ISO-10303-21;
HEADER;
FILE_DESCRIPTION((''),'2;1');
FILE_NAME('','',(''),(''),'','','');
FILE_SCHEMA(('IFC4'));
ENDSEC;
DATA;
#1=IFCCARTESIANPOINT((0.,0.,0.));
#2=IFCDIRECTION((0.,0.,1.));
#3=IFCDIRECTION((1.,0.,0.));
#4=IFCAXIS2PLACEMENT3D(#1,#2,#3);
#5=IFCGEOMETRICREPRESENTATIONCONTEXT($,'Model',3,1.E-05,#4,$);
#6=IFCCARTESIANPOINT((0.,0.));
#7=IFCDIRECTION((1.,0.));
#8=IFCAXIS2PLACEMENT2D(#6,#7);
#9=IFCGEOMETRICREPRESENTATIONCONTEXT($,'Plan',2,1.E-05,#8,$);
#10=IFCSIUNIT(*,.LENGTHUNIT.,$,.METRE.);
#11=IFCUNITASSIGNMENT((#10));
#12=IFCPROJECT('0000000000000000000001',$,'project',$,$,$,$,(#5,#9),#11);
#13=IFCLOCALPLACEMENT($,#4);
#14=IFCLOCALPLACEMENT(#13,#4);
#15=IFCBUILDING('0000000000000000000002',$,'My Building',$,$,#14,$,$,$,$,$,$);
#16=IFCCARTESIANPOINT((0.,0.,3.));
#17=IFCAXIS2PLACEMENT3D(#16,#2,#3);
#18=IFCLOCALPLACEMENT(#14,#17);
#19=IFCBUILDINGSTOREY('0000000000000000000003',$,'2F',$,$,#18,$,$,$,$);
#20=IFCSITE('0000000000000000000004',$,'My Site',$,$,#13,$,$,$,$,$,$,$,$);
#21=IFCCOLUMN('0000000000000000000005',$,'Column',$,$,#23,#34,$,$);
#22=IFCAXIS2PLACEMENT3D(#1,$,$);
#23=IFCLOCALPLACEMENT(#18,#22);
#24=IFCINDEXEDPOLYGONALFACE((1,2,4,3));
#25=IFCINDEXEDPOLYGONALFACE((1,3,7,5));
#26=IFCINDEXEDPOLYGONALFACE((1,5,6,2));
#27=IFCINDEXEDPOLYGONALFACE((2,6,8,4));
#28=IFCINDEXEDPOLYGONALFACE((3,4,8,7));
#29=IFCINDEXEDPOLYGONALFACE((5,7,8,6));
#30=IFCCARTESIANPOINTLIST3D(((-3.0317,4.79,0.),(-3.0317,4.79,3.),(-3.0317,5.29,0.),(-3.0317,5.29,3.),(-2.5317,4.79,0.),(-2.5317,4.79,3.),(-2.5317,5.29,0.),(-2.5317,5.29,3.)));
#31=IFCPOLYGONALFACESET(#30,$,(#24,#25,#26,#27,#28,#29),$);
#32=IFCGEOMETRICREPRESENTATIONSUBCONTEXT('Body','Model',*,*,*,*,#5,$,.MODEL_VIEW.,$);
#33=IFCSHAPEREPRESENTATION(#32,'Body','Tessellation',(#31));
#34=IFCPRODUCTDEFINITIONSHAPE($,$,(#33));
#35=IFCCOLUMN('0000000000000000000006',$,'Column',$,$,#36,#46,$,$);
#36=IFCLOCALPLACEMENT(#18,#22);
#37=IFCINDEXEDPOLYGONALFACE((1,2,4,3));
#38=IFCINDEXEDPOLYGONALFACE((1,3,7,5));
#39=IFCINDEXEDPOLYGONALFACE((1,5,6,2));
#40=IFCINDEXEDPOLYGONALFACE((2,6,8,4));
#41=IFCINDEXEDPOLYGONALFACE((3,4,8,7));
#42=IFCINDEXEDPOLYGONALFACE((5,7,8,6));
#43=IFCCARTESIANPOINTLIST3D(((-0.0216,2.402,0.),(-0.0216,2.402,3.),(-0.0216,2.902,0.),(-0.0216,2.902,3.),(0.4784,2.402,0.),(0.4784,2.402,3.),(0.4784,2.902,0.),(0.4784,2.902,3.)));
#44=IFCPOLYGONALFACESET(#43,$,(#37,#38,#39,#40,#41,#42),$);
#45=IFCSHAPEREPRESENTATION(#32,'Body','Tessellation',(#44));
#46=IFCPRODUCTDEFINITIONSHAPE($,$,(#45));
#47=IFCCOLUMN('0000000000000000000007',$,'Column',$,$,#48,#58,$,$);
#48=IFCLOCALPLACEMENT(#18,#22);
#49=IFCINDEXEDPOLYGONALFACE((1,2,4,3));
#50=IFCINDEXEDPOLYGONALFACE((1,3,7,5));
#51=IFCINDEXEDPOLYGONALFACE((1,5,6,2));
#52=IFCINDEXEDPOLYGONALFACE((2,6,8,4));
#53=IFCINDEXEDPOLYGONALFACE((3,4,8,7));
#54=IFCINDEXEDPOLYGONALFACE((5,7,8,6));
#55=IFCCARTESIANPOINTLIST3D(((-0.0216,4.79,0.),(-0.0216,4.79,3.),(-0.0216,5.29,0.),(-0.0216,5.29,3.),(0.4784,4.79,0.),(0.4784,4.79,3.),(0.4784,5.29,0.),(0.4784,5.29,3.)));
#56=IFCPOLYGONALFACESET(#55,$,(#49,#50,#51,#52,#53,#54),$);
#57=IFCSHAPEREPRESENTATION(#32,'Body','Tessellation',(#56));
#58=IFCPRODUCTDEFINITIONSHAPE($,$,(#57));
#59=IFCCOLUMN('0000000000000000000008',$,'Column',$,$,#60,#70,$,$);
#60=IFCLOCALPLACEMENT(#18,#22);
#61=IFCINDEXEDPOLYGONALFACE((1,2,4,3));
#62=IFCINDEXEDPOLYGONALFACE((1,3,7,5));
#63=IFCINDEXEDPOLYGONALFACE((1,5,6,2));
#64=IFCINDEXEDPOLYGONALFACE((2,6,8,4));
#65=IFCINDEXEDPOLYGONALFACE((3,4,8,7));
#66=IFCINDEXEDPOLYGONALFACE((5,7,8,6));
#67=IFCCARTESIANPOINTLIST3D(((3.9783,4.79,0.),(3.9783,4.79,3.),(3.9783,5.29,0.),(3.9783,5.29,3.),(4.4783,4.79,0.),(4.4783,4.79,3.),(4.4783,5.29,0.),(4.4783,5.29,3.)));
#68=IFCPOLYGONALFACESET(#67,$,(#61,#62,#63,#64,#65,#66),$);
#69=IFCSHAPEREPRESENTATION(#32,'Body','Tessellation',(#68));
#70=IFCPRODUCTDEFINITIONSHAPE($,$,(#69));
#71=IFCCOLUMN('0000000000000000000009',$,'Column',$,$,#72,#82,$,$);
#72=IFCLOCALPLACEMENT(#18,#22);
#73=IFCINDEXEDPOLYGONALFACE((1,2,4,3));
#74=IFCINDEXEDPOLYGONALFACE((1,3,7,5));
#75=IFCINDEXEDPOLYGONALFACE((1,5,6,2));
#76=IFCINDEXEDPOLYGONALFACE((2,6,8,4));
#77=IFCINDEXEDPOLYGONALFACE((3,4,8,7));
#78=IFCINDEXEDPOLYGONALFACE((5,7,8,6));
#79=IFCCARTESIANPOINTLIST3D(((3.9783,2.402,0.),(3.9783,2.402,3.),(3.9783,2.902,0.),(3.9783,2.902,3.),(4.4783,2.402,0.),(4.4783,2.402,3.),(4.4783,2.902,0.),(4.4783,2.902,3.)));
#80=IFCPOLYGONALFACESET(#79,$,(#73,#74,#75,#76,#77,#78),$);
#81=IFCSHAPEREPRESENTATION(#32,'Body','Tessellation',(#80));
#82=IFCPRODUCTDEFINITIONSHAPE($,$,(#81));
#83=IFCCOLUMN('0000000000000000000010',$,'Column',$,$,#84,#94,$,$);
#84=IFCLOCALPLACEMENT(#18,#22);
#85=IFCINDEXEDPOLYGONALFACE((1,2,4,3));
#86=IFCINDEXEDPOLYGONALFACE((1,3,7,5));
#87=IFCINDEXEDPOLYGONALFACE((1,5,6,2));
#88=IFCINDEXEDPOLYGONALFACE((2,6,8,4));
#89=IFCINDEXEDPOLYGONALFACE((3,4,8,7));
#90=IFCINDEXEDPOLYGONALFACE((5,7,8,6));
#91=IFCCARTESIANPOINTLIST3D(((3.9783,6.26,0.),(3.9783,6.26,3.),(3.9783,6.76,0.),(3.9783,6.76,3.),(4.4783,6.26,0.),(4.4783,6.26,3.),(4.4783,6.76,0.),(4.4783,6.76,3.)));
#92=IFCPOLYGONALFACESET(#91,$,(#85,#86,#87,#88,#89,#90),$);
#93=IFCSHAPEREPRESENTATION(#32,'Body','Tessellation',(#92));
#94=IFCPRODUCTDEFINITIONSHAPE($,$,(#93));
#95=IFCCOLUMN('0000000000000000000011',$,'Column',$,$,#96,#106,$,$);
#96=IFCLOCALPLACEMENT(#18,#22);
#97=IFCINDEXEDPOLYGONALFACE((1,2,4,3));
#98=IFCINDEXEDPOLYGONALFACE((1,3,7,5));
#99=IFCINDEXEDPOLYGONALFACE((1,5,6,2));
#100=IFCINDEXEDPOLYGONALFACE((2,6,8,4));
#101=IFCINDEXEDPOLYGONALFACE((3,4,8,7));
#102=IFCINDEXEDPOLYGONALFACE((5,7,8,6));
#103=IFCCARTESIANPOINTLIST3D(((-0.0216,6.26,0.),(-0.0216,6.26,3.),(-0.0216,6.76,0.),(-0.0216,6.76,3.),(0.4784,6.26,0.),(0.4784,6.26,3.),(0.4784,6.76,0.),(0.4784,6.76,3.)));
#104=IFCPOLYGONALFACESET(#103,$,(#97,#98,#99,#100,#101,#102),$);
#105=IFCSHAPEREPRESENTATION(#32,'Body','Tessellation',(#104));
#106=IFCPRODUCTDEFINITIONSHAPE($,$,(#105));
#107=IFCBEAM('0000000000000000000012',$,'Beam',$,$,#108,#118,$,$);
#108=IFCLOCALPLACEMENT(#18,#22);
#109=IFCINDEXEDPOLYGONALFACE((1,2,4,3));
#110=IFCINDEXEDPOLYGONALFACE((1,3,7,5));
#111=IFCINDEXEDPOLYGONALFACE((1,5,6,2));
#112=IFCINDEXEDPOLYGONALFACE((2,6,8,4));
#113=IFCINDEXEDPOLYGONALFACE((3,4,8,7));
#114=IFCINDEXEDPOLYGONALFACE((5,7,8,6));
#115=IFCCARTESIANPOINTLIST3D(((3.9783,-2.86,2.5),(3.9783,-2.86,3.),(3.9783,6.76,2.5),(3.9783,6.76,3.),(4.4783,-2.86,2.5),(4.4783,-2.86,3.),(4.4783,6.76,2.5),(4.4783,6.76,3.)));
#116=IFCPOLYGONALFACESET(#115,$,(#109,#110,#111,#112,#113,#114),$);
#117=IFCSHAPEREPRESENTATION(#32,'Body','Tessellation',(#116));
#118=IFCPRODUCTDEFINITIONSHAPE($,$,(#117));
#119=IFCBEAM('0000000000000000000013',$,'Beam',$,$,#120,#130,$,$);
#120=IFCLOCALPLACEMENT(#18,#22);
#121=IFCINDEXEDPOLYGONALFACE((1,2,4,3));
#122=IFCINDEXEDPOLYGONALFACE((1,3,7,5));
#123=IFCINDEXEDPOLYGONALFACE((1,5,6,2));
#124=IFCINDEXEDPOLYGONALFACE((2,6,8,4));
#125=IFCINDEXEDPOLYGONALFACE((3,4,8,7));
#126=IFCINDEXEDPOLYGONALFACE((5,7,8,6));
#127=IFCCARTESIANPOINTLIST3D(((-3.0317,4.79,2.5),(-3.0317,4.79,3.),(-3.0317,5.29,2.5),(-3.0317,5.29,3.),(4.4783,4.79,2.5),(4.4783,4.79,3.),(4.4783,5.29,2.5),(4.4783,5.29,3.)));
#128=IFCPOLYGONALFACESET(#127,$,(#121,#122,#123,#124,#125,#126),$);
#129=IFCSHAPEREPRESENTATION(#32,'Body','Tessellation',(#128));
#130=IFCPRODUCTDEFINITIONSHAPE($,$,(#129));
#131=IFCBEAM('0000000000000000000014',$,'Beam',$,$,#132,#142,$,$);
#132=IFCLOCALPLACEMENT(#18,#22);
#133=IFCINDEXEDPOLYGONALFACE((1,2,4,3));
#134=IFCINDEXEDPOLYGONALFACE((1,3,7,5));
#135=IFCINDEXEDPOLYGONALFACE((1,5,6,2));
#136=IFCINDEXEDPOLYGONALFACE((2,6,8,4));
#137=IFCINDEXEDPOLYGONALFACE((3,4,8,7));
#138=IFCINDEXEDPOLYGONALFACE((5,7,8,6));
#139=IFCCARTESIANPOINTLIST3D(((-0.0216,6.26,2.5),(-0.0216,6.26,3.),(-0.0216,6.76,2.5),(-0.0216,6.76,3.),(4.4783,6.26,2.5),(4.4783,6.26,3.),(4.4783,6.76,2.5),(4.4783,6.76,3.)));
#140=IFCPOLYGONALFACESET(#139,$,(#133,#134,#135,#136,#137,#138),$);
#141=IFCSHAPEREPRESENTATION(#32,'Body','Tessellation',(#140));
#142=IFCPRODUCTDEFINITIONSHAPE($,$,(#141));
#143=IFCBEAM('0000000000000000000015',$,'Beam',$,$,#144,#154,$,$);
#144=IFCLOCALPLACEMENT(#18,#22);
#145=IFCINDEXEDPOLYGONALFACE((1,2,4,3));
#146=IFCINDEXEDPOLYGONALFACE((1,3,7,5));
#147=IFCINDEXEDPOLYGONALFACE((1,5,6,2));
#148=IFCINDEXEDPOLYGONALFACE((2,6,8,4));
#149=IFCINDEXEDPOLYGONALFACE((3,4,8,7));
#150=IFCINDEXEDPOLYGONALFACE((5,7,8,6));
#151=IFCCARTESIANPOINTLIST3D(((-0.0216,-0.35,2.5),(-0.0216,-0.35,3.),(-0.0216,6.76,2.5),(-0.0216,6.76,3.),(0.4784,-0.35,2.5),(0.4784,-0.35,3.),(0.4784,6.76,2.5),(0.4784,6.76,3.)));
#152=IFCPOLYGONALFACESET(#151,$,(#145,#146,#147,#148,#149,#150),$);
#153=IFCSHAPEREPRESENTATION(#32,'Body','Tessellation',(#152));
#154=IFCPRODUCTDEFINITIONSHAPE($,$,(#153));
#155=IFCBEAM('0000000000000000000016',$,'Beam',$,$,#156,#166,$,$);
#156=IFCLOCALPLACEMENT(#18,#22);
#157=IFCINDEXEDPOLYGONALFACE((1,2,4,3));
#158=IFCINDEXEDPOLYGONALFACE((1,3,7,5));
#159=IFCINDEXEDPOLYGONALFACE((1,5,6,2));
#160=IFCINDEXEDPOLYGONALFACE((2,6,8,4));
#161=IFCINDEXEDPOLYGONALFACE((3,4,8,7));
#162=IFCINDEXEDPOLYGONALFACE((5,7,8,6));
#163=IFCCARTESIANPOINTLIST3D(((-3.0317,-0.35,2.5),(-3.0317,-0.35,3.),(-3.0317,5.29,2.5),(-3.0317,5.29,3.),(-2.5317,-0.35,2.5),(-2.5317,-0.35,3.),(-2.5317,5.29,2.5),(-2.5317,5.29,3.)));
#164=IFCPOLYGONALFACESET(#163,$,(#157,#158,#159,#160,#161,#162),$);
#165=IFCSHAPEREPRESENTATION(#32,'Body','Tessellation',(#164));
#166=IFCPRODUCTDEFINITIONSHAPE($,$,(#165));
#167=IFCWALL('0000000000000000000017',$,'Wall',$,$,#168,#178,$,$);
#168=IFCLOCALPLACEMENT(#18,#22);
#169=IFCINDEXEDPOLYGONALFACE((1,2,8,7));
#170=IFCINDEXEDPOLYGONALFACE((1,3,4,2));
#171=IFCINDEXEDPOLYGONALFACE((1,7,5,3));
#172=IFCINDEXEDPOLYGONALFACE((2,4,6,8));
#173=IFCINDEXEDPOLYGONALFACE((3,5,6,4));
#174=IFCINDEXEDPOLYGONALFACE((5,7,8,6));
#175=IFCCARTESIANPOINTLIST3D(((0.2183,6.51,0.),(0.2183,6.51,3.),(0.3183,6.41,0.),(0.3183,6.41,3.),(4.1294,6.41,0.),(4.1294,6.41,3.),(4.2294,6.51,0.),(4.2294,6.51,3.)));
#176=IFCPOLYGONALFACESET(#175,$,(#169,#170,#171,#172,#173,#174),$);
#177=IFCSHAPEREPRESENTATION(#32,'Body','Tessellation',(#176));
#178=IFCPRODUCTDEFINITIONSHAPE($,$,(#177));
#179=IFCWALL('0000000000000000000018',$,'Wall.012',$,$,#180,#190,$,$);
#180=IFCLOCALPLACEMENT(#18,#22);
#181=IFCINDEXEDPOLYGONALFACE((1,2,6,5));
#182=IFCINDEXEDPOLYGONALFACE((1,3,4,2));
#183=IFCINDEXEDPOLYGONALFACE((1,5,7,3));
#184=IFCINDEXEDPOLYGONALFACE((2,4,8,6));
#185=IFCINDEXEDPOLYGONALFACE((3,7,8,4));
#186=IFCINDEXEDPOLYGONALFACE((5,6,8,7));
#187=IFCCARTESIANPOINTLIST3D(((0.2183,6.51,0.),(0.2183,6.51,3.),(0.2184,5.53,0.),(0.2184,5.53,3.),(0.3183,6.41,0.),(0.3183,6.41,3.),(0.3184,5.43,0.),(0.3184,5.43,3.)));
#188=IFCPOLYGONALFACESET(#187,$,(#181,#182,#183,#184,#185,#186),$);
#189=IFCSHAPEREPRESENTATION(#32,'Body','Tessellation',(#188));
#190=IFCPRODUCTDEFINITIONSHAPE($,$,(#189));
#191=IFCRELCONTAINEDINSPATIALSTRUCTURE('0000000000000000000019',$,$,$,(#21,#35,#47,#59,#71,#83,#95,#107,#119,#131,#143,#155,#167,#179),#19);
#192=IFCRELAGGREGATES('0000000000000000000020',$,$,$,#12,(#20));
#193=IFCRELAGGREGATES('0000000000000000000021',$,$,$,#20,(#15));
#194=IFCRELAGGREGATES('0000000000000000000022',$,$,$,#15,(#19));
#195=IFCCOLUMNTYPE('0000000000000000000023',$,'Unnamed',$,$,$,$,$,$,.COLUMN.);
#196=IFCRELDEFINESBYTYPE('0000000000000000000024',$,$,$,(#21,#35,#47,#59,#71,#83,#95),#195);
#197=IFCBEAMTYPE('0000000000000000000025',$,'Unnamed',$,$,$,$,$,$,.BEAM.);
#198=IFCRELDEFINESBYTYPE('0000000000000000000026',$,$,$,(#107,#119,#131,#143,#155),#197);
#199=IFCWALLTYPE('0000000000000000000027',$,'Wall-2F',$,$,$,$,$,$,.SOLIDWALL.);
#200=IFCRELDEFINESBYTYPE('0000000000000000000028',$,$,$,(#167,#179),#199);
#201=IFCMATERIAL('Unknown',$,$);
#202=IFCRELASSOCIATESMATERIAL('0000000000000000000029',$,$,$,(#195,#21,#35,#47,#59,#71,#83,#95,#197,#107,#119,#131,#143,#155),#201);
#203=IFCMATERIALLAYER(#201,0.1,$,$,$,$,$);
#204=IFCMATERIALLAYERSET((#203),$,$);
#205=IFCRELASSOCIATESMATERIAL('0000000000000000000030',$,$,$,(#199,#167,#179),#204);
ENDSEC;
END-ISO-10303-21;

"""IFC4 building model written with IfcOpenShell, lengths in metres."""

from ifc_helpers import new_model, si_unit, frame, origin_with_axes, origin_2d_with_axis, place, context, subcontext, project, spatial, line, indexed_curve, rectangle, outline, extrude, material, layer, layer_set, layer_usage, material_profile, profile_set, profile_usage, type_object, element, save


model = new_model("IFC4")

# Units and contexts
model_context = context("Model", 3, precision=1e-05, world=origin_with_axes())
plan_context = context("Plan", 2, precision=1e-05, world=origin_2d_with_axis())
body_context_1 = subcontext(model_context, "Body", "Model", "MODEL_VIEW")
ifc_project = project(units=[si_unit("LENGTHUNIT", "METRE")], contexts=[model_context, plan_context])

# Site, building, storey
site_placement = place(None, origin_with_axes())
site = spatial("IfcSite", under=ifc_project, at=site_placement, Name="My Site")
building_placement = place(site_placement, origin_with_axes())
building = spatial("IfcBuilding", under=site, at=building_placement, Name="My Building")
storey_placement = place(building_placement, frame((0.0, 0.0, 3.0), z_axis=(0.0, 0.0, 1.0), x_axis=(1.0, 0.0, 0.0)))
storey = spatial("IfcBuildingStorey", under=building, at=storey_placement, Name="2F")

# Columns
ifc_material = material(Name="Unknown")
ifc_material_profile_1 = material_profile(ifc_material, rectangle(XDim=0.5, YDim=0.5))
ifc_profile_set_1 = profile_set([ifc_material_profile_1])
ifc_profile_usage_1 = profile_usage(ifc_profile_set_1, cardinal=7)
column_type = type_object("IfcColumnType", Name="Unnamed", PredefinedType="COLUMN", material=ifc_profile_set_1)
column_1_placement = place(storey_placement, frame((-2.5317, 5.29, 0.0), z_axis=(0.0, 0.0, 1.0), x_axis=(1.0, 0.0, 0.0)))
element("IfcColumn", 1, at=column_1_placement, inside=storey, type_object=column_type, material=ifc_profile_usage_1, Name="Column", context=body_context_1, shape_type="SweptSolid", body=[
    extrude(rectangle(XDim=0.5, YDim=0.5), frame((-0.25, -0.25, 0.0), z_axis=(0.0, 0.0, 1.0), x_axis=(1.0, 0.0, 0.0)), (0.0, 0.0, 1.0), 3.0),
])
ifc_profile_usage_2 = profile_usage(ifc_profile_set_1, cardinal=7)
column_2_placement = place(storey_placement, frame((0.4784, 2.902, 0.0), z_axis=(0.0, 0.0, 1.0), x_axis=(1.0, 0.0, 0.0)))
element("IfcColumn", 2, at=column_2_placement, inside=storey, type_object=column_type, material=ifc_profile_usage_2, Name="Column", context=body_context_1, shape_type="SweptSolid", body=[
    extrude(rectangle(XDim=0.5, YDim=0.5), frame((-0.25, -0.25, 0.0), z_axis=(0.0, 0.0, 1.0), x_axis=(1.0, 0.0, 0.0)), (0.0, 0.0, 1.0), 3.0),
])
ifc_profile_usage_3 = profile_usage(ifc_profile_set_1, cardinal=7)
column_3_placement = place(storey_placement, frame((0.4784, 5.29, 0.0), z_axis=(0.0, 0.0, 1.0), x_axis=(1.0, 0.0, 0.0)))
element("IfcColumn", 3, at=column_3_placement, inside=storey, type_object=column_type, material=ifc_profile_usage_3, Name="Column", context=body_context_1, shape_type="SweptSolid", body=[
    extrude(rectangle(XDim=0.5, YDim=0.5), frame((-0.25, -0.25, 0.0), z_axis=(0.0, 0.0, 1.0), x_axis=(1.0, 0.0, 0.0)), (0.0, 0.0, 1.0), 3.0),
])
ifc_profile_usage_4 = profile_usage(ifc_profile_set_1, cardinal=7)
column_4_placement = place(storey_placement, frame((4.4783, 5.29, 0.0), z_axis=(0.0, 0.0, 1.0), x_axis=(1.0, 0.0, 0.0)))
element("IfcColumn", 4, at=column_4_placement, inside=storey, type_object=column_type, material=ifc_profile_usage_4, Name="Column", context=body_context_1, shape_type="SweptSolid", body=[
    extrude(rectangle(XDim=0.5, YDim=0.5), frame((-0.25, -0.25, 0.0), z_axis=(0.0, 0.0, 1.0), x_axis=(1.0, 0.0, 0.0)), (0.0, 0.0, 1.0), 3.0),
])
ifc_profile_usage_5 = profile_usage(ifc_profile_set_1, cardinal=7)
column_5_placement = place(storey_placement, frame((4.4783, 2.902, 0.0), z_axis=(0.0, 0.0, 1.0), x_axis=(1.0, 0.0, 0.0)))
element("IfcColumn", 5, at=column_5_placement, inside=storey, type_object=column_type, material=ifc_profile_usage_5, Name="Column", context=body_context_1, shape_type="SweptSolid", body=[
    extrude(rectangle(XDim=0.5, YDim=0.5), frame((-0.25, -0.25, 0.0), z_axis=(0.0, 0.0, 1.0), x_axis=(1.0, 0.0, 0.0)), (0.0, 0.0, 1.0), 3.0),
])
ifc_profile_usage_6 = profile_usage(ifc_profile_set_1, cardinal=7)
column_6_placement = place(storey_placement, frame((4.4783, 6.76, 0.0), z_axis=(0.0, 0.0, 1.0), x_axis=(1.0, 0.0, 0.0)))
element("IfcColumn", 6, at=column_6_placement, inside=storey, type_object=column_type, material=ifc_profile_usage_6, Name="Column", context=body_context_1, shape_type="SweptSolid", body=[
    extrude(rectangle(XDim=0.5, YDim=0.5), frame((-0.25, -0.25, 0.0), z_axis=(0.0, 0.0, 1.0), x_axis=(1.0, 0.0, 0.0)), (0.0, 0.0, 1.0), 3.0),
])
ifc_profile_usage_7 = profile_usage(ifc_profile_set_1, cardinal=7)
column_7_placement = place(storey_placement, frame((0.4784, 6.76, 0.0), z_axis=(0.0, 0.0, 1.0), x_axis=(1.0, 0.0, 0.0)))
element("IfcColumn", 7, at=column_7_placement, inside=storey, type_object=column_type, material=ifc_profile_usage_7, Name="Column", context=body_context_1, shape_type="SweptSolid", body=[
    extrude(rectangle(XDim=0.5, YDim=0.5), frame((-0.25, -0.25, 0.0), z_axis=(0.0, 0.0, 1.0), x_axis=(1.0, 0.0, 0.0)), (0.0, 0.0, 1.0), 3.0),
])

# Beams
ifc_material_profile_2 = material_profile(ifc_material, rectangle(XDim=0.5, YDim=0.5))
ifc_profile_set_2 = profile_set([ifc_material_profile_2])
ifc_profile_usage_8 = profile_usage(ifc_profile_set_2, cardinal=7)
beam_type = type_object("IfcBeamType", Name="Unnamed", PredefinedType="BEAM", material=ifc_profile_set_2)
beam_1_placement = place(storey_placement, frame((4.4783, 6.76, 3.0), z_axis=(0.0, -1.0, 0.0), x_axis=(1.0, 0.0, 0.0)))
element("IfcBeam", 8, at=beam_1_placement, inside=storey, type_object=beam_type, material=ifc_profile_usage_8, Name="Beam", context=body_context_1, shape_type="SweptSolid", body=[
    extrude(rectangle(XDim=0.5, YDim=0.5), frame((-0.25, -0.25, 0.0), z_axis=(0.0, 0.0, 1.0), x_axis=(1.0, 0.0, 0.0)), (0.0, 0.0, 1.0), 9.62),
])
ifc_profile_usage_9 = profile_usage(ifc_profile_set_2, cardinal=7)
beam_2_placement = place(storey_placement, frame((4.4783, 4.79, 3.0), z_axis=(-1.0, 0.0, 0.0), x_axis=(0.0, -1.0, 0.0)))
element("IfcBeam", 9, at=beam_2_placement, inside=storey, type_object=beam_type, material=ifc_profile_usage_9, Name="Beam", context=body_context_1, shape_type="SweptSolid", body=[
    extrude(rectangle(XDim=0.5, YDim=0.5), frame((-0.25, -0.25, 0.0), z_axis=(0.0, 0.0, 1.0), x_axis=(1.0, 0.0, 0.0)), (0.0, 0.0, 1.0), 7.51),
])
ifc_profile_usage_10 = profile_usage(ifc_profile_set_2, cardinal=7)
beam_3_placement = place(storey_placement, frame((4.4783, 6.26, 3.0), z_axis=(-1.0, 0.0, 0.0), x_axis=(0.0, -1.0, 0.0)))
element("IfcBeam", 10, at=beam_3_placement, inside=storey, type_object=beam_type, material=ifc_profile_usage_10, Name="Beam", context=body_context_1, shape_type="SweptSolid", body=[
    extrude(rectangle(XDim=0.5, YDim=0.5), frame((-0.25, -0.25, 0.0), z_axis=(0.0, 0.0, 1.0), x_axis=(1.0, 0.0, 0.0)), (0.0, 0.0, 1.0), 4.5),
])
ifc_profile_usage_11 = profile_usage(ifc_profile_set_2, cardinal=7)
beam_4_placement = place(storey_placement, frame((0.4784, 6.76, 3.0), z_axis=(0.0, -1.0, 0.0), x_axis=(1.0, 0.0, 0.0)))
element("IfcBeam", 11, at=beam_4_placement, inside=storey, type_object=beam_type, material=ifc_profile_usage_11, Name="Beam", context=body_context_1, shape_type="SweptSolid", body=[
    extrude(rectangle(XDim=0.5, YDim=0.5), frame((-0.25, -0.25, 0.0), z_axis=(0.0, 0.0, 1.0), x_axis=(1.0, 0.0, 0.0)), (0.0, 0.0, 1.0), 7.11),
])
ifc_profile_usage_12 = profile_usage(ifc_profile_set_2, cardinal=7)
beam_5_placement = place(storey_placement, frame((-2.5317, 5.29, 3.0), z_axis=(0.0, -1.0, 0.0), x_axis=(1.0, 0.0, 0.0)))
element("IfcBeam", 12, at=beam_5_placement, inside=storey, type_object=beam_type, material=ifc_profile_usage_12, Name="Beam", context=body_context_1, shape_type="SweptSolid", body=[
    extrude(rectangle(XDim=0.5, YDim=0.5), frame((-0.25, -0.25, 0.0), z_axis=(0.0, 0.0, 1.0), x_axis=(1.0, 0.0, 0.0)), (0.0, 0.0, 1.0), 5.64),
])

# Walls
ifc_layer = layer(ifc_material, 0.1)
ifc_layer_set = layer_set([ifc_layer])
ifc_layer_usage_1 = layer_usage(ifc_layer_set, "AXIS2", "POSITIVE", 0.0)
wall_type = type_object("IfcWallType", Name="Wall-2F", PredefinedType="SOLIDWALL", material=ifc_layer_set)
wall_1_placement = place(storey_placement, frame((4.2294, 6.51, 0.0), z_axis=(0.0, 0.0, 1.0), x_axis=(-1.0, 0.0, 0.0)))
element("IfcWall", 13, at=wall_1_placement, inside=storey, type_object=wall_type, material=ifc_layer_usage_1, Name="Wall", context=body_context_1, shape_type="SweptSolid", body=[
    extrude(outline(indexed_curve([(0.0, 0.0), (0.1, 0.1), (3.9111, 0.1), (4.0111, 0.0)], segments=[line(1, 2, 3, 4, 1)])), origin_with_axes(), (0.0, 0.0, 1.0), 3.0),
])
ifc_layer_usage_2 = layer_usage(ifc_layer_set, "AXIS2", "POSITIVE", 0.0)
wall_2_placement = place(storey_placement, frame((0.2183, 6.51, 0.0), z_axis=(0.0, 0.0, 1.0), x_axis=(0.0, -1.0, 0.0)))
element("IfcWall", 14, at=wall_2_placement, inside=storey, type_object=wall_type, material=ifc_layer_usage_2, Name="Wall.012", context=body_context_1, shape_type="SweptSolid", body=[
    extrude(outline(indexed_curve([(0.0, 0.0), (0.1, 0.1), (1.08, 0.1), (0.98, 0.0)], segments=[line(1, 2, 3, 4, 1)])), origin_with_axes(), (0.0, 0.0, 1.0), 3.0),
])

save(model, "model.ifc")
